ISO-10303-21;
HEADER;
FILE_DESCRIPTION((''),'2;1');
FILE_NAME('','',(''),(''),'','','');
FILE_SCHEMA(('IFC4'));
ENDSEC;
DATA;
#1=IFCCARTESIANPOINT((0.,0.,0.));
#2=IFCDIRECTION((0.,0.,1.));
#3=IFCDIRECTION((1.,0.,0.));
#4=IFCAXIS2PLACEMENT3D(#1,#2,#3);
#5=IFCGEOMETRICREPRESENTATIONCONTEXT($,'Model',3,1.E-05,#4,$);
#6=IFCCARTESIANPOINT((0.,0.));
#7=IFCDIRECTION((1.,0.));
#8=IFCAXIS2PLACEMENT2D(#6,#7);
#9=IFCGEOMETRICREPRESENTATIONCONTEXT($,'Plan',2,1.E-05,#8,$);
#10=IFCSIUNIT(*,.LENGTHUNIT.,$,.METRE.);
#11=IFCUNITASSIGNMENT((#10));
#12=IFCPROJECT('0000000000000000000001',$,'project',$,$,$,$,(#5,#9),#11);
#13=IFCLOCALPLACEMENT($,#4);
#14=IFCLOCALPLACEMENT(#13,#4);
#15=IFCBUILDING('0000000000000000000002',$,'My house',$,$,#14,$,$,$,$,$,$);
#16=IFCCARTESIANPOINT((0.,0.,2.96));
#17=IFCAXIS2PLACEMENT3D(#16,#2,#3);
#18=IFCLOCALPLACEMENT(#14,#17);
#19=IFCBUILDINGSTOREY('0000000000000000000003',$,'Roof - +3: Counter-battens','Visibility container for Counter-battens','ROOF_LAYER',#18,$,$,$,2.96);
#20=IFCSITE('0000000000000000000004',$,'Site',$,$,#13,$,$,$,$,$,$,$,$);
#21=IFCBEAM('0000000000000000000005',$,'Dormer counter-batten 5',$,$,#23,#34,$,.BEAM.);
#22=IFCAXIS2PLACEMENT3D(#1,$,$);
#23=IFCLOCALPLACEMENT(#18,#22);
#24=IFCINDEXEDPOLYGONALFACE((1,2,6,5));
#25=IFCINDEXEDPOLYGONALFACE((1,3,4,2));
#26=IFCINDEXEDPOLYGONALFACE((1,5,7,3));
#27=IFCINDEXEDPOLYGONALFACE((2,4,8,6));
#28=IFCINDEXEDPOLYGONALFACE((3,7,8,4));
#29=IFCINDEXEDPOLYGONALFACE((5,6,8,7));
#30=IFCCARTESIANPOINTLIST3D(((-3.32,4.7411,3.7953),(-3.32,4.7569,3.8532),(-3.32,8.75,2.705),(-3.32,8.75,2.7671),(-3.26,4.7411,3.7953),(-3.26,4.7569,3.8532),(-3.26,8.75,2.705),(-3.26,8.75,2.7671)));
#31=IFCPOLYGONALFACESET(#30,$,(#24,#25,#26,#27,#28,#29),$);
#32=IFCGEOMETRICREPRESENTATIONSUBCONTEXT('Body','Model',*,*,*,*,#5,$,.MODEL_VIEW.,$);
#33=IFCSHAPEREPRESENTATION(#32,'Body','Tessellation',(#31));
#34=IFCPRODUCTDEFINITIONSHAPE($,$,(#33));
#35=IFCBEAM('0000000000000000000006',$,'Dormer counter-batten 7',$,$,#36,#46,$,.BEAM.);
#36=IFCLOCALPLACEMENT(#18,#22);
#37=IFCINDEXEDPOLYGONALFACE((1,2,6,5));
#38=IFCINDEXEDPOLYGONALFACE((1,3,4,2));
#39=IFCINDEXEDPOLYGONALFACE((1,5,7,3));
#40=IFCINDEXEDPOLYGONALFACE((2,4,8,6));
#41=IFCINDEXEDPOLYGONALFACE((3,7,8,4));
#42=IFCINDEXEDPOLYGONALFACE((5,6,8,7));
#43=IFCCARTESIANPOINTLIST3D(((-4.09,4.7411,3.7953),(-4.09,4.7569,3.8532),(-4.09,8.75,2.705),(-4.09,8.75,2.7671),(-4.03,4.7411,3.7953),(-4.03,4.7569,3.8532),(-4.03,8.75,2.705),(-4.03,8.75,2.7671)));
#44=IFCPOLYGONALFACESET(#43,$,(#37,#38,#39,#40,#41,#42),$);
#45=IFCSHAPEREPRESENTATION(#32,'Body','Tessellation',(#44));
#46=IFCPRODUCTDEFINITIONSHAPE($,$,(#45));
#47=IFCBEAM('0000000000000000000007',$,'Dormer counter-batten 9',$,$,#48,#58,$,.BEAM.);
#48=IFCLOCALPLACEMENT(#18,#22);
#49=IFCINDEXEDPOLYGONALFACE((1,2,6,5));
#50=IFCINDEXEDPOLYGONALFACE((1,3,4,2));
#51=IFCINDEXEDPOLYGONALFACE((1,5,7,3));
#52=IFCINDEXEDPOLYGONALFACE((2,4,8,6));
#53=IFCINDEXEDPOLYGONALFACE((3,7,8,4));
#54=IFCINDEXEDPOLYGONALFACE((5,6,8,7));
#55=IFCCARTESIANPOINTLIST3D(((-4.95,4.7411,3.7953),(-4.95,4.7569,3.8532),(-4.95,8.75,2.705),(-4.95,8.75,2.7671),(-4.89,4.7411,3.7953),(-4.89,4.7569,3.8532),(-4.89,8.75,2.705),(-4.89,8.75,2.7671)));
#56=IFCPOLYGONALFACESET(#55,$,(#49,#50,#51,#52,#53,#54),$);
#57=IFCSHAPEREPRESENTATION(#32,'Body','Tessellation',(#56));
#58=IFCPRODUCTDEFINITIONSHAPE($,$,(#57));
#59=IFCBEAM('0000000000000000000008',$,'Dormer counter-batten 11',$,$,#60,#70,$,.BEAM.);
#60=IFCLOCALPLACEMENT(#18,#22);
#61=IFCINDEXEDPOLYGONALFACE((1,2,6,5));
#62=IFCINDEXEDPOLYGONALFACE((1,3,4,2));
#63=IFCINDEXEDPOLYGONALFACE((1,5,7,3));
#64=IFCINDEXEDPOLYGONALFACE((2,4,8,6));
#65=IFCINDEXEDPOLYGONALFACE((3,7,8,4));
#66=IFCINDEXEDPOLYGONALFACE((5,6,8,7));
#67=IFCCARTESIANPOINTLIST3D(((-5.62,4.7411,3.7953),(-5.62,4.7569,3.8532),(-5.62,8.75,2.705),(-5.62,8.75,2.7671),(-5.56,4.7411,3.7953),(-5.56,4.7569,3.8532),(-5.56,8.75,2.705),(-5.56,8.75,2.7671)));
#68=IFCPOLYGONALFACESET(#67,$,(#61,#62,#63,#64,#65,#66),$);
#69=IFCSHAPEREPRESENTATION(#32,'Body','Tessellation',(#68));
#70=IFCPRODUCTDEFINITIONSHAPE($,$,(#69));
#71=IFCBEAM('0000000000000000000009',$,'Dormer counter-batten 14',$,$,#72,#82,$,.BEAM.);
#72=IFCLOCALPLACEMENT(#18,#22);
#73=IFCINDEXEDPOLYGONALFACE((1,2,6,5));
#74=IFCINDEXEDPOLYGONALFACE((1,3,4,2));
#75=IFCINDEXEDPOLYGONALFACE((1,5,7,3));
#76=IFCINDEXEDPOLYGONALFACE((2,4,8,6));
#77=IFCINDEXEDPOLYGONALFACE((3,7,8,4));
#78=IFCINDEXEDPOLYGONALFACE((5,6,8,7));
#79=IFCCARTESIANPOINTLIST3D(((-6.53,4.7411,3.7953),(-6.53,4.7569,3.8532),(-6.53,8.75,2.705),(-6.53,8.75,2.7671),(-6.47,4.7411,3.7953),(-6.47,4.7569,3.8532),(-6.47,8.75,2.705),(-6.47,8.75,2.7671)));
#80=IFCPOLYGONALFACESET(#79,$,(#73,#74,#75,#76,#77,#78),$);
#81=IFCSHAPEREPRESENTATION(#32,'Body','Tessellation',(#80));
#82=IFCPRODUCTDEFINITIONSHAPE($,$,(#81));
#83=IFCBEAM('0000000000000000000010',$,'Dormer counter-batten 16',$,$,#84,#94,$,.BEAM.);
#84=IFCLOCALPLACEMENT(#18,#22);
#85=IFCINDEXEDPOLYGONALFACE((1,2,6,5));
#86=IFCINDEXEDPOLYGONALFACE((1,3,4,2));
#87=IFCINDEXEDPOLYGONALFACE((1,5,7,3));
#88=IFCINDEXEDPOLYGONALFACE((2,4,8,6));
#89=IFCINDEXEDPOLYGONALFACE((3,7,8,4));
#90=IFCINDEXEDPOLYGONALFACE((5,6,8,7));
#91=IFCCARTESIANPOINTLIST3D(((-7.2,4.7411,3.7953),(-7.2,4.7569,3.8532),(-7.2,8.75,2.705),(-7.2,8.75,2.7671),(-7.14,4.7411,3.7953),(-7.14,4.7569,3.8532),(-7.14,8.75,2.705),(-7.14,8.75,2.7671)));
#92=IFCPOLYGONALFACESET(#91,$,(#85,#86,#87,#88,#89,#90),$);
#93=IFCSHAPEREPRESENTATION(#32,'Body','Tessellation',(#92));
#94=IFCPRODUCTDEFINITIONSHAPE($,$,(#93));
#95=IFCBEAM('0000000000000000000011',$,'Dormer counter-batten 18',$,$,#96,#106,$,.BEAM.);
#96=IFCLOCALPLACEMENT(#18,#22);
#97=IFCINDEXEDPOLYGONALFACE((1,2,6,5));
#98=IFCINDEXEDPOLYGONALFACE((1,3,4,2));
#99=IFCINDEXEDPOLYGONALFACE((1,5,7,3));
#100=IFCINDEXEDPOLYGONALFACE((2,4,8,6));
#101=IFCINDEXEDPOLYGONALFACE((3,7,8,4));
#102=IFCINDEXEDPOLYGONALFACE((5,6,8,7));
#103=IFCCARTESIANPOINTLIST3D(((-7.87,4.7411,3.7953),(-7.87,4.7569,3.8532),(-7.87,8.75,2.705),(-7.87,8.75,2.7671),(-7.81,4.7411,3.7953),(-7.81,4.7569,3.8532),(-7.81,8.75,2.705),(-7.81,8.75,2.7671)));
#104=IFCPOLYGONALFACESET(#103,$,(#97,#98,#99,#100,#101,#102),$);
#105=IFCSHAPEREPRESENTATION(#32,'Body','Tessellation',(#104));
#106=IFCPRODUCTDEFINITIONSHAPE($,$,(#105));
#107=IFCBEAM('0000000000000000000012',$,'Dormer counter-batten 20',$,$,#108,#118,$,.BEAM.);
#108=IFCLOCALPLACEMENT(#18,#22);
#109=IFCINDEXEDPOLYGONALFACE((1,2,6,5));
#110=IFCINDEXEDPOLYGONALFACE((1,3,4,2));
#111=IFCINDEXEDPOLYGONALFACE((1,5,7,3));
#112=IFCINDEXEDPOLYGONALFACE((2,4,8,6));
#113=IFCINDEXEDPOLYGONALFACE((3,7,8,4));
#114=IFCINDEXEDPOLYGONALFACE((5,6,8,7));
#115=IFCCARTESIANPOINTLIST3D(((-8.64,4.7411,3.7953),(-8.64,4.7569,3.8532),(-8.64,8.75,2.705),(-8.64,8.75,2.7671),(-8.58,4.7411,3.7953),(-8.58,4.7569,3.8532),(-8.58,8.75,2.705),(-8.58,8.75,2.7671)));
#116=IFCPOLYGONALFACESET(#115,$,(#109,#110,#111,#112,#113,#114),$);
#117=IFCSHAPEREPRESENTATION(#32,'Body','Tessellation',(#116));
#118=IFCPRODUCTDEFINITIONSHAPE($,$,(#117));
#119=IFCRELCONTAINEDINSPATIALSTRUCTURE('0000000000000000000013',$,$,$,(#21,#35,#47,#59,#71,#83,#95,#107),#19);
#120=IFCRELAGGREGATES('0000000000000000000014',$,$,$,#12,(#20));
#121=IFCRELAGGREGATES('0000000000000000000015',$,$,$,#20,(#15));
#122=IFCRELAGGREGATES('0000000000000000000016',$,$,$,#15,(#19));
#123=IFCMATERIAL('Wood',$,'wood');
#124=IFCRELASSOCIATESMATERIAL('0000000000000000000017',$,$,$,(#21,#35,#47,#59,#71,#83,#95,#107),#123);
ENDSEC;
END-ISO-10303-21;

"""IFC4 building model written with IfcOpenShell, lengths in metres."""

from ifc_helpers import new_model, si_unit, frame, origin_with_axes, origin_2d_with_axis, place, context, subcontext, project, spatial, rectangle, extrude, clip, halfspace, source, transform, mapped, material, element, save


model = new_model("IFC4")

# Units and contexts
model_context = context("Model", 3, precision=1e-05, world=origin_with_axes())
plan_context = context("Plan", 2, precision=1e-05, world=origin_2d_with_axis())
body_context = subcontext(model_context, "Body", "Model", "MODEL_VIEW")
ifc_project = project(units=[si_unit("LENGTHUNIT", "METRE")], contexts=[model_context, plan_context])

# Site, building, storey
site_placement = place(None, origin_with_axes())
site = spatial("IfcSite", under=ifc_project, at=site_placement, Name="Site")
building_placement = place(site_placement, origin_with_axes())
building = spatial("IfcBuilding", under=site, at=building_placement, Name="My house")
storey_placement = place(building_placement, frame((0.0, 0.0, 2.96), z_axis=(0.0, 0.0, 1.0), x_axis=(1.0, 0.0, 0.0)))
storey = spatial("IfcBuildingStorey", under=building, at=storey_placement, Name="Roof - +3: Counter-battens", Description="Visibility container for Counter-battens", ObjectType="ROOF_LAYER", Elevation=2.96)

# Beams
ifc_material = material(Name="Wood", Category="wood")
shared_shape_1 = source(origin_with_axes(), body_context, "Body", "Clipping", [
    clip(clip(extrude(rectangle(XDim=0.06, YDim=0.06), frame((0.0, 0.0, 0.0), z_axis=(1.0, 0.0, 0.0), x_axis=(0.0, 1.0, 0.0)), (0.0, 0.0, 1.0), 5.5), halfspace(frame((1.0577, 3.29, -6.743), z_axis=(-0.964948, 0.0, -0.262441), x_axis=(0.0, 1.0, 0.0)), False)), halfspace(frame((5.6412, 3.29, -5.4964), z_axis=(0.964948, 0.0, 0.262441), x_axis=(0.0, -1.0, 0.0)), False)),
])
beam_1_placement = place(storey_placement, frame((-3.29, 4.749, 3.8242), z_axis=(0.0, 0.262441, 0.964948), x_axis=(0.0, -0.964948, 0.262441)))
element("IfcBeam", 1, at=beam_1_placement, inside=storey, material=ifc_material, Name="Dormer counter-batten 5", PredefinedType="BEAM", context=body_context, shape_type="MappedRepresentation", body=[
    mapped(shared_shape_1, transform((0.0, 0.0, 0.0), x_axis=(-1.0, 0.0, 0.0), y_axis=(0.0, 1.0, 0.0), z_axis=(0.0, 0.0, 1.0), scale=1.0)),
])
shared_shape_2 = source(origin_with_axes(), body_context, "Body", "Clipping", [
    clip(clip(extrude(rectangle(XDim=0.06, YDim=0.06), frame((0.0, 0.0, 0.0), z_axis=(1.0, 0.0, 0.0), x_axis=(0.0, 1.0, 0.0)), (0.0, 0.0, 1.0), 5.5), halfspace(frame((1.0577, 4.06, -6.743), z_axis=(-0.964948, 0.0, -0.262441), x_axis=(0.0, 1.0, 0.0)), False)), halfspace(frame((5.6412, 4.06, -5.4964), z_axis=(0.964948, 0.0, 0.262441), x_axis=(0.0, -1.0, 0.0)), False)),
])
beam_2_placement = place(storey_placement, frame((-4.06, 4.749, 3.8242), z_axis=(0.0, 0.262441, 0.964948), x_axis=(0.0, -0.964948, 0.262441)))
element("IfcBeam", 2, at=beam_2_placement, inside=storey, material=ifc_material, Name="Dormer counter-batten 7", PredefinedType="BEAM", context=body_context, shape_type="MappedRepresentation", body=[
    mapped(shared_shape_2, transform((0.0, 0.0, 0.0), x_axis=(-1.0, 0.0, 0.0), y_axis=(0.0, 1.0, 0.0), z_axis=(0.0, 0.0, 1.0), scale=1.0)),
])
shared_shape_3 = source(origin_with_axes(), body_context, "Body", "Clipping", [
    clip(clip(extrude(rectangle(XDim=0.06, YDim=0.06), frame((0.0, 0.0, 0.0), z_axis=(1.0, 0.0, 0.0), x_axis=(0.0, 1.0, 0.0)), (0.0, 0.0, 1.0), 5.5), halfspace(frame((1.0577, 4.92, -6.743), z_axis=(-0.964948, 0.0, -0.262441), x_axis=(0.0, 1.0, 0.0)), False)), halfspace(frame((5.6412, 4.92, -5.4964), z_axis=(0.964948, 0.0, 0.262441), x_axis=(0.0, -1.0, 0.0)), False)),
])
beam_3_placement = place(storey_placement, frame((-4.92, 4.749, 3.8242), z_axis=(0.0, 0.262441, 0.964948), x_axis=(0.0, -0.964948, 0.262441)))
element("IfcBeam", 3, at=beam_3_placement, inside=storey, material=ifc_material, Name="Dormer counter-batten 9", PredefinedType="BEAM", context=body_context, shape_type="MappedRepresentation", body=[
    mapped(shared_shape_3, transform((0.0, 0.0, 0.0), x_axis=(-1.0, 0.0, 0.0), y_axis=(0.0, 1.0, 0.0), z_axis=(0.0, 0.0, 1.0), scale=1.0)),
])
shared_shape_4 = source(origin_with_axes(), body_context, "Body", "Clipping", [
    clip(clip(extrude(rectangle(XDim=0.06, YDim=0.06), frame((0.0, 0.0, 0.0), z_axis=(1.0, 0.0, 0.0), x_axis=(0.0, 1.0, 0.0)), (0.0, 0.0, 1.0), 5.5), halfspace(frame((1.0577, 5.59, -6.743), z_axis=(-0.964948, 0.0, -0.262441), x_axis=(0.0, 1.0, 0.0)), False)), halfspace(frame((5.6412, 5.59, -5.4964), z_axis=(0.964948, 0.0, 0.262441), x_axis=(0.0, -1.0, 0.0)), False)),
])
beam_4_placement = place(storey_placement, frame((-5.59, 4.749, 3.8242), z_axis=(0.0, 0.262441, 0.964948), x_axis=(0.0, -0.964948, 0.262441)))
element("IfcBeam", 4, at=beam_4_placement, inside=storey, material=ifc_material, Name="Dormer counter-batten 11", PredefinedType="BEAM", context=body_context, shape_type="MappedRepresentation", body=[
    mapped(shared_shape_4, transform((0.0, 0.0, 0.0), x_axis=(-1.0, 0.0, 0.0), y_axis=(0.0, 1.0, 0.0), z_axis=(0.0, 0.0, 1.0), scale=1.0)),
])
shared_shape_5 = source(origin_with_axes(), body_context, "Body", "Clipping", [
    clip(clip(extrude(rectangle(XDim=0.06, YDim=0.06), frame((0.0, 0.0, 0.0), z_axis=(1.0, 0.0, 0.0), x_axis=(0.0, 1.0, 0.0)), (0.0, 0.0, 1.0), 5.5), halfspace(frame((1.0577, 6.5, -6.743), z_axis=(-0.964948, 0.0, -0.262441), x_axis=(0.0, 1.0, 0.0)), False)), halfspace(frame((5.6412, 6.5, -5.4964), z_axis=(0.964948, 0.0, 0.262441), x_axis=(0.0, -1.0, 0.0)), False)),
])
beam_5_placement = place(storey_placement, frame((-6.5, 4.749, 3.8242), z_axis=(0.0, 0.262441, 0.964948), x_axis=(0.0, -0.964948, 0.262441)))
element("IfcBeam", 5, at=beam_5_placement, inside=storey, material=ifc_material, Name="Dormer counter-batten 14", PredefinedType="BEAM", context=body_context, shape_type="MappedRepresentation", body=[
    mapped(shared_shape_5, transform((0.0, 0.0, 0.0), x_axis=(-1.0, 0.0, 0.0), y_axis=(0.0, 1.0, 0.0), z_axis=(0.0, 0.0, 1.0), scale=1.0)),
])
shared_shape_6 = source(origin_with_axes(), body_context, "Body", "Clipping", [
    clip(clip(extrude(rectangle(XDim=0.06, YDim=0.06), frame((0.0, 0.0, 0.0), z_axis=(1.0, 0.0, 0.0), x_axis=(0.0, 1.0, 0.0)), (0.0, 0.0, 1.0), 5.5), halfspace(frame((1.0577, 7.17, -6.743), z_axis=(-0.964948, 0.0, -0.262441), x_axis=(0.0, 1.0, 0.0)), False)), halfspace(frame((5.6412, 7.17, -5.4964), z_axis=(0.964948, 0.0, 0.262441), x_axis=(0.0, -1.0, 0.0)), False)),
])
beam_6_placement = place(storey_placement, frame((-7.17, 4.749, 3.8242), z_axis=(0.0, 0.262441, 0.964948), x_axis=(0.0, -0.964948, 0.262441)))
element("IfcBeam", 6, at=beam_6_placement, inside=storey, material=ifc_material, Name="Dormer counter-batten 16", PredefinedType="BEAM", context=body_context, shape_type="MappedRepresentation", body=[
    mapped(shared_shape_6, transform((0.0, 0.0, 0.0), x_axis=(-1.0, 0.0, 0.0), y_axis=(0.0, 1.0, 0.0), z_axis=(0.0, 0.0, 1.0), scale=1.0)),
])
shared_shape_7 = source(origin_with_axes(), body_context, "Body", "Clipping", [
    clip(clip(extrude(rectangle(XDim=0.06, YDim=0.06), frame((0.0, 0.0, 0.0), z_axis=(1.0, 0.0, 0.0), x_axis=(0.0, 1.0, 0.0)), (0.0, 0.0, 1.0), 5.5), halfspace(frame((1.0577, 7.84, -6.743), z_axis=(-0.964948, 0.0, -0.262441), x_axis=(0.0, 1.0, 0.0)), False)), halfspace(frame((5.6412, 7.84, -5.4964), z_axis=(0.964948, 0.0, 0.262441), x_axis=(0.0, -1.0, 0.0)), False)),
])
beam_7_placement = place(storey_placement, frame((-7.84, 4.749, 3.8242), z_axis=(0.0, 0.262441, 0.964948), x_axis=(0.0, -0.964948, 0.262441)))
element("IfcBeam", 7, at=beam_7_placement, inside=storey, material=ifc_material, Name="Dormer counter-batten 18", PredefinedType="BEAM", context=body_context, shape_type="MappedRepresentation", body=[
    mapped(shared_shape_7, transform((0.0, 0.0, 0.0), x_axis=(-1.0, 0.0, 0.0), y_axis=(0.0, 1.0, 0.0), z_axis=(0.0, 0.0, 1.0), scale=1.0)),
])
shared_shape_8 = source(origin_with_axes(), body_context, "Body", "Clipping", [
    clip(clip(extrude(rectangle(XDim=0.06, YDim=0.06), frame((0.0, 0.0, 0.0), z_axis=(1.0, 0.0, 0.0), x_axis=(0.0, 1.0, 0.0)), (0.0, 0.0, 1.0), 5.5), halfspace(frame((1.0577, 8.61, -6.743), z_axis=(-0.964948, 0.0, -0.262441), x_axis=(0.0, 1.0, 0.0)), False)), halfspace(frame((5.6412, 8.61, -5.4964), z_axis=(0.964948, 0.0, 0.262441), x_axis=(0.0, -1.0, 0.0)), False)),
])
beam_8_placement = place(storey_placement, frame((-8.61, 4.749, 3.8242), z_axis=(0.0, 0.262441, 0.964948), x_axis=(0.0, -0.964948, 0.262441)))
element("IfcBeam", 8, at=beam_8_placement, inside=storey, material=ifc_material, Name="Dormer counter-batten 20", PredefinedType="BEAM", context=body_context, shape_type="MappedRepresentation", body=[
    mapped(shared_shape_8, transform((0.0, 0.0, 0.0), x_axis=(-1.0, 0.0, 0.0), y_axis=(0.0, 1.0, 0.0), z_axis=(0.0, 0.0, 1.0), scale=1.0)),
])

save(model, "model.ifc")
